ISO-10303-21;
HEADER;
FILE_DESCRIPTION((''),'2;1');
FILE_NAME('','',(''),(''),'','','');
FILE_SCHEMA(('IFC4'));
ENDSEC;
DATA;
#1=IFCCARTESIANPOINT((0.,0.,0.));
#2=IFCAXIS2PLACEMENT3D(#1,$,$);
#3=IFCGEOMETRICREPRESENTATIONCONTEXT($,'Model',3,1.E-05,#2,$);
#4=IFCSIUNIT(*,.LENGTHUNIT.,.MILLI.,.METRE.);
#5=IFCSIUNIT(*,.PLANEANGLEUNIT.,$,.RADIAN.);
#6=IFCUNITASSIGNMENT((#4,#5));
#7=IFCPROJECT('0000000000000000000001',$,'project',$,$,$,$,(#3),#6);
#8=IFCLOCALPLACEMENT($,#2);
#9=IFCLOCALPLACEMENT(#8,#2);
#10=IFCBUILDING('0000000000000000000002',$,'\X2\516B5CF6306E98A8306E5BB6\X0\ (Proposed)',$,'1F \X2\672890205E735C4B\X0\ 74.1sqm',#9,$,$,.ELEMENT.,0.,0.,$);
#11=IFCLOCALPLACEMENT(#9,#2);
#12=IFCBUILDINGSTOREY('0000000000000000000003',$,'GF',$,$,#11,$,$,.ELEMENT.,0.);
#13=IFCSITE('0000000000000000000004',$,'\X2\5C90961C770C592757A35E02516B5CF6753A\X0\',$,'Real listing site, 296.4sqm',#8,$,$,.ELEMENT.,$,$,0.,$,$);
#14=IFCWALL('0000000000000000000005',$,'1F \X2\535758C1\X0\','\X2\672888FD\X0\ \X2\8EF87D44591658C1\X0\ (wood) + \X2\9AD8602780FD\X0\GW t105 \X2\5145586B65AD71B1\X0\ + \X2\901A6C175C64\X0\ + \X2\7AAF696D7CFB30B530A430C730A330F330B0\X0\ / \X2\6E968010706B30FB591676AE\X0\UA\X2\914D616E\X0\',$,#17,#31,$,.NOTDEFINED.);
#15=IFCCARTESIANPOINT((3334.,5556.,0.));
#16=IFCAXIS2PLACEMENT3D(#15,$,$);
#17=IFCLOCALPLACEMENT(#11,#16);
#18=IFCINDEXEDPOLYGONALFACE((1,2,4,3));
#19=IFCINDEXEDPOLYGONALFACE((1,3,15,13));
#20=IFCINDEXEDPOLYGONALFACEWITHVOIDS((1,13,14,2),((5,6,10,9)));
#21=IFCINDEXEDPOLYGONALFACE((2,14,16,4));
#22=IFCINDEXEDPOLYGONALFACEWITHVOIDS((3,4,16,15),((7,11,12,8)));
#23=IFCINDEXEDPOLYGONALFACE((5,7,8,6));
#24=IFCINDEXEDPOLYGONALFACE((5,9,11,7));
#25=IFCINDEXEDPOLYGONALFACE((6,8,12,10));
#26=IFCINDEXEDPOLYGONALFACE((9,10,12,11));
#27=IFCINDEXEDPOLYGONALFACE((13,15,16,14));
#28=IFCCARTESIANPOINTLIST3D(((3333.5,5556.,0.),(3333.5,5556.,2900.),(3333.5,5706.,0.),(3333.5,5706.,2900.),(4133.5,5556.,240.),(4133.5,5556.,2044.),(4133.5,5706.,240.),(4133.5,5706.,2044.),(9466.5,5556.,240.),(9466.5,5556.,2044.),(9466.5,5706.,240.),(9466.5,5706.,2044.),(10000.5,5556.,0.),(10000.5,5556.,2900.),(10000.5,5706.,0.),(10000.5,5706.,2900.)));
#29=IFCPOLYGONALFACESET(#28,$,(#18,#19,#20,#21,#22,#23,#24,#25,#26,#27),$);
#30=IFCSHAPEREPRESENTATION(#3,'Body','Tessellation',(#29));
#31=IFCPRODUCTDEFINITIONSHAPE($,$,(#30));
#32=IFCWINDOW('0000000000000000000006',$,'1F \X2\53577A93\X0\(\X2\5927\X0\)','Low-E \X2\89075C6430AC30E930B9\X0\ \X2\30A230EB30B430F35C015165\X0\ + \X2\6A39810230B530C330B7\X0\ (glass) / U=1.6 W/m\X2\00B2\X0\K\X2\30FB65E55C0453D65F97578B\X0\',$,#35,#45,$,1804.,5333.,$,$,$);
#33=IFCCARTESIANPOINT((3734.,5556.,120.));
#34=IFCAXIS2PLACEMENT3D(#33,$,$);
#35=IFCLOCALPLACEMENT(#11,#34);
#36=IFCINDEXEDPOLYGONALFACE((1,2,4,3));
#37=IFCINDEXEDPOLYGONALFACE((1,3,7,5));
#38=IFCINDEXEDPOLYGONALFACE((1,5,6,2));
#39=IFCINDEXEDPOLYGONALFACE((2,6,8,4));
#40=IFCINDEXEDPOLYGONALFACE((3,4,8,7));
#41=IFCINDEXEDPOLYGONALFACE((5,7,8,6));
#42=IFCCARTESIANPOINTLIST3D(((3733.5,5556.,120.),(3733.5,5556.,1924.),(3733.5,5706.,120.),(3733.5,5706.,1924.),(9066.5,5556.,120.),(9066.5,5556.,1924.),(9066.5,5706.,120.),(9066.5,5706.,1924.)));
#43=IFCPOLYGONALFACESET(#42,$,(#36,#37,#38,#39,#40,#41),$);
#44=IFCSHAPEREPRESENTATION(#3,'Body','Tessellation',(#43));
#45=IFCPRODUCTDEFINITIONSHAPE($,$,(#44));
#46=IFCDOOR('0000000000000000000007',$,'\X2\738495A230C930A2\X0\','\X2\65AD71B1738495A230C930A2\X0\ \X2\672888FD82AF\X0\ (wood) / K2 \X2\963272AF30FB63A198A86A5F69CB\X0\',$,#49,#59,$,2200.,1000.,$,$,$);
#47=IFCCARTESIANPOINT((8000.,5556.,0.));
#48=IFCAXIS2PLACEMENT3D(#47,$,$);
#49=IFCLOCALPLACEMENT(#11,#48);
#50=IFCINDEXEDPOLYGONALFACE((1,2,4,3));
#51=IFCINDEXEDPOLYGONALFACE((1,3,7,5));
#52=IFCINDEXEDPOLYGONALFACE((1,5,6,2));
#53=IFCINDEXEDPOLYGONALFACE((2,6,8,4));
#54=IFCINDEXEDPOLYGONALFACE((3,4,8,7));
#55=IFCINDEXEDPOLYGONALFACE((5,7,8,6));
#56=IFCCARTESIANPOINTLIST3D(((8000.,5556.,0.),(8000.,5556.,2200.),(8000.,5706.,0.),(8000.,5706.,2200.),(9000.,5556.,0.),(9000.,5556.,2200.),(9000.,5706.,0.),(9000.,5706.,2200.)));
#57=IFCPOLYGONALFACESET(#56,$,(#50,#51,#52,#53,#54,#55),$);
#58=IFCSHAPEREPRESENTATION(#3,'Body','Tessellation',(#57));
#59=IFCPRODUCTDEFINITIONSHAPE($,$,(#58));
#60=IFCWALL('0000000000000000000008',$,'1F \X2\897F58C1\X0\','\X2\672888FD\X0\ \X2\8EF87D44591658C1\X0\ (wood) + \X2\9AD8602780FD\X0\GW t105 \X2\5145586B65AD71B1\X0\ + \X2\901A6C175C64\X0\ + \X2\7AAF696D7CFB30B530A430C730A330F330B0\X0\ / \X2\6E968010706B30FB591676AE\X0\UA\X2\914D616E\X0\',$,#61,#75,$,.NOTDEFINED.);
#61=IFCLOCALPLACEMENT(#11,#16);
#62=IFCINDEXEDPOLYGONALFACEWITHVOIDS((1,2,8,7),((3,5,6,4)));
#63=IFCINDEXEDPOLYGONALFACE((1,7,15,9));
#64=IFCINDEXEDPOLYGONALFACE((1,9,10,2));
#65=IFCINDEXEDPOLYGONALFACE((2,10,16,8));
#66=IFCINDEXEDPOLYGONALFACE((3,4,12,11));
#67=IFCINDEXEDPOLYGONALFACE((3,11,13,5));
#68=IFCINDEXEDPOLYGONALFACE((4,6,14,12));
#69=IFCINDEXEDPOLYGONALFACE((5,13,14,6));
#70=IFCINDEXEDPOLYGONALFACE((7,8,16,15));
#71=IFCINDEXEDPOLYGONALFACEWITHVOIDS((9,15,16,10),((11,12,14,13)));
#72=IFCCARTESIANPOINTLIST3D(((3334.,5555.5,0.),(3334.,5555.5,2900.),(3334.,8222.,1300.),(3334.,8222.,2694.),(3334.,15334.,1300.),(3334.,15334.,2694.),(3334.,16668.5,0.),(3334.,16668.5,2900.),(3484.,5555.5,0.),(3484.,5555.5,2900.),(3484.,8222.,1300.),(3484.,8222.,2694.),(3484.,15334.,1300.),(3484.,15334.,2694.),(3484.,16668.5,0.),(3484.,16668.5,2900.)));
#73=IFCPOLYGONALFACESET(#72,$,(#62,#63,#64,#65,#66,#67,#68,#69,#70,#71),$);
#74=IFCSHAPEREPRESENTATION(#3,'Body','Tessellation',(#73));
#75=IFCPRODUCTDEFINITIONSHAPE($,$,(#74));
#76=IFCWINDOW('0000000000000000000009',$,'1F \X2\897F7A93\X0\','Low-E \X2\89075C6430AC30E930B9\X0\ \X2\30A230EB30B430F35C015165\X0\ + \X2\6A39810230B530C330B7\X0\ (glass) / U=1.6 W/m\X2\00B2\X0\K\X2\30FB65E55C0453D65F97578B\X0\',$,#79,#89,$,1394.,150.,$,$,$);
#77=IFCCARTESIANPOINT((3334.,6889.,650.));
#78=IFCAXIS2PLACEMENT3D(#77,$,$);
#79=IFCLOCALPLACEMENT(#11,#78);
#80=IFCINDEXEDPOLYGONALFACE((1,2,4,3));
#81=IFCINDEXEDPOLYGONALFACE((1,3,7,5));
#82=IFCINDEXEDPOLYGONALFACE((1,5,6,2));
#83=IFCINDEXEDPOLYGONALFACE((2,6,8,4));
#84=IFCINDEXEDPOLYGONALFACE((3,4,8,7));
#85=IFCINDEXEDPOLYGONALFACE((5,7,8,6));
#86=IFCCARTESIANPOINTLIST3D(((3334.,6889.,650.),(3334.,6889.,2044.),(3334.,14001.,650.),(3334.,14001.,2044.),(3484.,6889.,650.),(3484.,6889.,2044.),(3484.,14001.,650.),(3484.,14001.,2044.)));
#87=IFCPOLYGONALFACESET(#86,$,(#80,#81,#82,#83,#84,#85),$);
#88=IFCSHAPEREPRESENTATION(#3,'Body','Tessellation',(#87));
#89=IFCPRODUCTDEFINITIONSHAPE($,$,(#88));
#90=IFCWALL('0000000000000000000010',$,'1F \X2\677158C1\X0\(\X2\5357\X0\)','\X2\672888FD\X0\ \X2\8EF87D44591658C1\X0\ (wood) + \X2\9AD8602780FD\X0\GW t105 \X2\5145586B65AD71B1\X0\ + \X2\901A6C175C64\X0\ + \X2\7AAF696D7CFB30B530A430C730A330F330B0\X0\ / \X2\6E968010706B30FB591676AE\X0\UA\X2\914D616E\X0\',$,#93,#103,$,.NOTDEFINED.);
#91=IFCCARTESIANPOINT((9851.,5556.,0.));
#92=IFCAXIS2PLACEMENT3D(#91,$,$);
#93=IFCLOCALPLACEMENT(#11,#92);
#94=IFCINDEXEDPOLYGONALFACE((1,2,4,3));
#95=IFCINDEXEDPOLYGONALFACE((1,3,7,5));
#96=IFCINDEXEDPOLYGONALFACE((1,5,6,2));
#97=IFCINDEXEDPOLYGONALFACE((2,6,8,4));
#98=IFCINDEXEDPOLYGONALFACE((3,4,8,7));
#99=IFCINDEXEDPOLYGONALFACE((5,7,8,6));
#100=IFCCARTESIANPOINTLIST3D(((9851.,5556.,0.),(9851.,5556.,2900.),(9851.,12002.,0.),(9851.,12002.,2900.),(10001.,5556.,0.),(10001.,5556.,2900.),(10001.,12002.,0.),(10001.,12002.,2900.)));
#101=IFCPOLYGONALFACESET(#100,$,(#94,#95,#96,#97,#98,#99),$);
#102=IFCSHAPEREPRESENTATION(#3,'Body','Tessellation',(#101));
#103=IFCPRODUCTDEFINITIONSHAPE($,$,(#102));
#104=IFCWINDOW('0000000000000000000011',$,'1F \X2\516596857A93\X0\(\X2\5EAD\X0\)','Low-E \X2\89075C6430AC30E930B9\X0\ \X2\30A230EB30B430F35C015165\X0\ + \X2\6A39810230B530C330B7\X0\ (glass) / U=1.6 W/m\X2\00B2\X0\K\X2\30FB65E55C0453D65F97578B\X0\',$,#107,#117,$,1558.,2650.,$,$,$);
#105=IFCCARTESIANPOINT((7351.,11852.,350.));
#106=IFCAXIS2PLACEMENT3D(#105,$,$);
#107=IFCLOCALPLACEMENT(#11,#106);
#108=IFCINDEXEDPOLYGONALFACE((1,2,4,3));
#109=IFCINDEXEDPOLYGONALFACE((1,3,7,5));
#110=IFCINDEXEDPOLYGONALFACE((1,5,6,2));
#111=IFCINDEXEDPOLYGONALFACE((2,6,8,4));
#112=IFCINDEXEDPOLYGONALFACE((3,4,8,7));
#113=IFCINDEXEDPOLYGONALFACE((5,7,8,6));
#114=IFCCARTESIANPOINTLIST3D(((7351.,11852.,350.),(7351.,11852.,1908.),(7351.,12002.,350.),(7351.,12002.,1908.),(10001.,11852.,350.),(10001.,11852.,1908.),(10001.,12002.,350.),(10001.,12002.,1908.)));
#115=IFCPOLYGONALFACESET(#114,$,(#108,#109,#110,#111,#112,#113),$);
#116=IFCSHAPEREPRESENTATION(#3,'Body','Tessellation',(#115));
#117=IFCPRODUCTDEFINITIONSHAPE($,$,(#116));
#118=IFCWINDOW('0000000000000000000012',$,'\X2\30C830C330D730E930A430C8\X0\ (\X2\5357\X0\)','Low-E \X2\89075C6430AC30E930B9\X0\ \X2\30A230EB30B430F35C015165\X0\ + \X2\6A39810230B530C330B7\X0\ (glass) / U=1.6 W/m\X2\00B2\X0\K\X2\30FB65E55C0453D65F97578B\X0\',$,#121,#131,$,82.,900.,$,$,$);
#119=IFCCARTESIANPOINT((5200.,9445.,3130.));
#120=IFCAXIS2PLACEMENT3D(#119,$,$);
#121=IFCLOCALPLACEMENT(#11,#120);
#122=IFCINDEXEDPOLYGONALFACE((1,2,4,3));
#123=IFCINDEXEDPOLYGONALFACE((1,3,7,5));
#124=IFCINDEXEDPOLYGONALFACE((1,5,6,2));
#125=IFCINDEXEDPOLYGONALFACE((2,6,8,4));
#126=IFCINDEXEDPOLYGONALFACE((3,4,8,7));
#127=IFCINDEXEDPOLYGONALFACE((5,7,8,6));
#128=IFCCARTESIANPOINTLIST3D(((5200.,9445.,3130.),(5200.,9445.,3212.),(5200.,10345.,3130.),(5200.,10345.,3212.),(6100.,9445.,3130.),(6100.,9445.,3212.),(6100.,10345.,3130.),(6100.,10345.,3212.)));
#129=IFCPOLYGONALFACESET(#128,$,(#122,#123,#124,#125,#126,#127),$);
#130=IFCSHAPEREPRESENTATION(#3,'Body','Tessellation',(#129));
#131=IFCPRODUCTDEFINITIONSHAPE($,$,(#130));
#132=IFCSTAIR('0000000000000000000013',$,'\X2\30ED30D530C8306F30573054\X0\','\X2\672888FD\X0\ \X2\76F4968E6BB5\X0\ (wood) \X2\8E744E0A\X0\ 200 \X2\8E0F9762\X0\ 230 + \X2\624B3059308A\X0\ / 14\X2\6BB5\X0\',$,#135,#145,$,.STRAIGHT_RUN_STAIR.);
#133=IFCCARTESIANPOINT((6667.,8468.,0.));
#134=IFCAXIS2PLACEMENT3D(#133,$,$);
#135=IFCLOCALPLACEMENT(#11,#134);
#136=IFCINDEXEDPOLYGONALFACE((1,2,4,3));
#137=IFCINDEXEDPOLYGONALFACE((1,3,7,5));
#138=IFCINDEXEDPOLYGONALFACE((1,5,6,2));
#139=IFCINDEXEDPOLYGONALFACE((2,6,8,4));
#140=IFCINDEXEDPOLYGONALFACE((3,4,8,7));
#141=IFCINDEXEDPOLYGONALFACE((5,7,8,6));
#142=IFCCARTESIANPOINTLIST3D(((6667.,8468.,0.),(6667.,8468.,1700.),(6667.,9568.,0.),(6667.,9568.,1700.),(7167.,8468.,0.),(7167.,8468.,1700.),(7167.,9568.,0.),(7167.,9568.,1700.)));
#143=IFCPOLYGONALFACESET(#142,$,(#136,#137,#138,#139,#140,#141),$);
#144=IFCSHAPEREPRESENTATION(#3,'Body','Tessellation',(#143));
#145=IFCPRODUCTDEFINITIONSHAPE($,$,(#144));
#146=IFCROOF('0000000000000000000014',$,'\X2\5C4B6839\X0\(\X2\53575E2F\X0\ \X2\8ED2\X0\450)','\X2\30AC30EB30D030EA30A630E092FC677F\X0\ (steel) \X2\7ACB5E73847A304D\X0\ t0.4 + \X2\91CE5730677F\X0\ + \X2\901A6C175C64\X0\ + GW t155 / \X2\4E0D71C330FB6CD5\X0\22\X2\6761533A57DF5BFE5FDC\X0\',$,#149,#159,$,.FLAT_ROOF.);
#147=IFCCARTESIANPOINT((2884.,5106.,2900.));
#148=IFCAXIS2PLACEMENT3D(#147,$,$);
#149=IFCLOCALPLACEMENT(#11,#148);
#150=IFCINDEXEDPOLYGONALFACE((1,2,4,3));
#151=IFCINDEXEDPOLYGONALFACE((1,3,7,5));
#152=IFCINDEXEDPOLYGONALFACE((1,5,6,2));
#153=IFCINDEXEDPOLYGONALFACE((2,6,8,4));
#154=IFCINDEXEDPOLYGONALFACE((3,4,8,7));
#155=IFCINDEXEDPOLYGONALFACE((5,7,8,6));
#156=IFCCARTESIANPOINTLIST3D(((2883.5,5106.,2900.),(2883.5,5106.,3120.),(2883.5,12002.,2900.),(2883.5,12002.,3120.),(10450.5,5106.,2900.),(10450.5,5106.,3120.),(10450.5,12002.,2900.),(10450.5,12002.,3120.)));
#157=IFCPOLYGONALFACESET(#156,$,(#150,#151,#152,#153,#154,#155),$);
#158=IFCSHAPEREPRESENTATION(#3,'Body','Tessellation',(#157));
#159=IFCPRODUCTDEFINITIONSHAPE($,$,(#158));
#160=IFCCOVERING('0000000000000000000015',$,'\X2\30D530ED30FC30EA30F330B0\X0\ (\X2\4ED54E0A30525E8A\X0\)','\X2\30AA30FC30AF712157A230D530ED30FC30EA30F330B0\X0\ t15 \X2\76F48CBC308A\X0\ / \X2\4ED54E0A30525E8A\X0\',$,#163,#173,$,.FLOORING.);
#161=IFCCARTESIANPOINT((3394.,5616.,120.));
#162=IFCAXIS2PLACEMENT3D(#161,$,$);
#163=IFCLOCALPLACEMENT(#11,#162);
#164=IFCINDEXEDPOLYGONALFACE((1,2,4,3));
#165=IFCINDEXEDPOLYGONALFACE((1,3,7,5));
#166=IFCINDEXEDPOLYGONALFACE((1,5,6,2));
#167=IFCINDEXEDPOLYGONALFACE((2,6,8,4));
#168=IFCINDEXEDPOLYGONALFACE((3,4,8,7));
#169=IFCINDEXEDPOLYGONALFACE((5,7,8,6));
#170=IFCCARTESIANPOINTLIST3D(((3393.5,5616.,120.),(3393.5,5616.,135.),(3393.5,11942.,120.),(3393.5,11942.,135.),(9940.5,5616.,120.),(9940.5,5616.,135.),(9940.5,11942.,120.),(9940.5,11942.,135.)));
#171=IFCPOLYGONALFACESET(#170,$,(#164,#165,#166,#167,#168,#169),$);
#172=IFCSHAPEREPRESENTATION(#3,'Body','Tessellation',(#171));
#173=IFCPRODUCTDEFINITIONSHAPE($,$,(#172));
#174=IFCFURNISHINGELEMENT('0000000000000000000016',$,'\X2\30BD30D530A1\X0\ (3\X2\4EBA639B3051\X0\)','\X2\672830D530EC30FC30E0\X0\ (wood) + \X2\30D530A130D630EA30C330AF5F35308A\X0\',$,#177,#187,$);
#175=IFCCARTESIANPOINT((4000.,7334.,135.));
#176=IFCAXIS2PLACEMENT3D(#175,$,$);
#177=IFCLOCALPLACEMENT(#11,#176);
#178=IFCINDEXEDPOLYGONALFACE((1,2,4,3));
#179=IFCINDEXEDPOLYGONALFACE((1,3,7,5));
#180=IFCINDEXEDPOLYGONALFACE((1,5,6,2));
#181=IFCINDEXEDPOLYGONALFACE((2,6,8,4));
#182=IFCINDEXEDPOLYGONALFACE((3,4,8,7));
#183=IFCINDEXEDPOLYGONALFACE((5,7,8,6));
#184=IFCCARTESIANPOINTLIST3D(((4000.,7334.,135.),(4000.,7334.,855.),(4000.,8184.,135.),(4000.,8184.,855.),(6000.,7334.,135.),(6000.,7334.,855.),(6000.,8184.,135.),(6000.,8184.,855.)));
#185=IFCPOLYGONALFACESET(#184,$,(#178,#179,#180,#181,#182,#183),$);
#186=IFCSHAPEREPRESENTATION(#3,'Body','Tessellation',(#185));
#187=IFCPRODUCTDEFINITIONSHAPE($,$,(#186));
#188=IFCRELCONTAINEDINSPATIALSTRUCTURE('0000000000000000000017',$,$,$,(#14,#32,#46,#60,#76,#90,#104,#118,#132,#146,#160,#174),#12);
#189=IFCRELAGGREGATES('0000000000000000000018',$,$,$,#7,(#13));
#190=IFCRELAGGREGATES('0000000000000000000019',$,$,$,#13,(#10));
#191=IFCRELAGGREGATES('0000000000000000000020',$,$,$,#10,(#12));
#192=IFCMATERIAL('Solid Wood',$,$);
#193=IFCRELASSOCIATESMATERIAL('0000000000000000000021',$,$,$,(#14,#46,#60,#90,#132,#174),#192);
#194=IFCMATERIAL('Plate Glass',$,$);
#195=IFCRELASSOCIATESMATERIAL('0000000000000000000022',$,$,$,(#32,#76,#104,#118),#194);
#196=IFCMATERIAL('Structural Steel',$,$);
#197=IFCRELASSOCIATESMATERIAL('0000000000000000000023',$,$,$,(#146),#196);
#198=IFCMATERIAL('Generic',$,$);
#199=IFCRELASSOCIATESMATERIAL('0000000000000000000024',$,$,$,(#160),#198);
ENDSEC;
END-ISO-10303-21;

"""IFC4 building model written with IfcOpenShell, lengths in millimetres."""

from ifc_helpers import new_model, si_unit, frame, frame_2d, origin, place, context, project, spatial, rectangle, extrude, material, element, fill, save


model = new_model("IFC4")

# Units and contexts
model_context = context("Model", 3, precision=1e-05, world=origin())
ifc_project = project(units=[si_unit("LENGTHUNIT", "METRE", prefix="MILLI"), si_unit("PLANEANGLEUNIT", "RADIAN")], contexts=[model_context])

# Site, building, storey
site_placement = place(None, origin())
site = spatial("IfcSite", under=ifc_project, at=site_placement, Name="岐阜県大垣市八島町", ObjectType="Real listing site, 296.4sqm", CompositionType="ELEMENT", RefElevation=0.0)
building_placement = place(site_placement, origin())
building = spatial("IfcBuilding", under=site, at=building_placement, Name="八島の風の家 (Proposed)", ObjectType="1F 木造平屋 74.1sqm", CompositionType="ELEMENT", ElevationOfRefHeight=0.0, ElevationOfTerrain=0.0)
storey_placement = place(building_placement, origin())
storey = spatial("IfcBuildingStorey", under=building, at=storey_placement, Name="GF", CompositionType="ELEMENT", Elevation=0.0)

# Shared definitions
ifc_material_1 = material(Name="Solid Wood")

# Wall, openings, window, door
wall_1_placement = place(storey_placement, frame((3334.0, 5556.0, 0.0)))
wall_1 = element("IfcWall", 1, at=wall_1_placement, inside=storey, material=ifc_material_1, Name="1F 南壁", Description="木製 軸組外壁 (wood) + 高性能GW t105 充填断熱 + 通気層 + 窯業系サイディング / 準耐火・外皮UA配慮", PredefinedType="NOTDEFINED", context=model_context, shape_type="SweptSolid", body=[
    extrude(rectangle(XDim=6667.0, YDim=150.0, at=frame_2d((3333.0, 75.0))), frame((3334.0, 5556.0, 0.0)), (0.0, 0.0, 1.0), 2900.0),
])
opening_1_placement = place(storey_placement, frame((3734.0, 5556.0, 120.0)))
opening_1 = element("IfcOpeningElement", 2, at=opening_1_placement, cuts=wall_1, PredefinedType="NOTDEFINED", context=model_context, shape_type="SweptSolid", body=[
    extrude(rectangle(XDim=5333.0, YDim=150.0, at=frame_2d((2666.0, 75.0))), frame((3734.0, 5556.0, 120.0)), (0.0, 0.0, 1.0), 1804.0),
])
opening_2_placement = place(storey_placement, frame((8000.0, 5556.0, 0.0)))
opening_2 = element("IfcOpeningElement", 3, at=opening_2_placement, cuts=wall_1, PredefinedType="NOTDEFINED", context=model_context, shape_type="SweptSolid", body=[
    extrude(rectangle(XDim=1000.0, YDim=150.0, at=frame_2d((500.0, 75.0))), frame((8000.0, 5556.0, 0.0)), (0.0, 0.0, 1.0), 2200.0),
])
ifc_material_2 = material(Name="Plate Glass")
window_1_placement = place(storey_placement, frame((3734.0, 5556.0, 120.0)))
window_1 = element("IfcWindow", 4, at=window_1_placement, inside=storey, material=ifc_material_2, Name="1F 南窓(大)", Description="Low-E 複層ガラス アルゴン封入 + 樹脂サッシ (glass) / U=1.6 W/m²K・日射取得型", OverallHeight=1804.0, OverallWidth=5333.0, context=model_context, shape_type="SweptSolid", body=[
    extrude(rectangle(XDim=5333.0, YDim=150.0, at=frame_2d((2666.0, 75.0))), frame((3734.0, 5556.0, 120.0)), (0.0, 0.0, 1.0), 1804.0),
])
fill(opening_1, window_1)
door_1_placement = place(storey_placement, frame((8000.0, 5556.0, 0.0)))
door_1 = element("IfcDoor", 5, at=door_1_placement, inside=storey, material=ifc_material_1, Name="玄関ドア", Description="断熱玄関ドア 木製芯 (wood) / K2 防犯・採風機構", OverallHeight=2200.0, OverallWidth=1000.0, context=model_context, shape_type="SweptSolid", body=[
    extrude(rectangle(XDim=1000.0, YDim=150.0, at=frame_2d((500.0, 75.0))), frame((8000.0, 5556.0, 0.0)), (0.0, 0.0, 1.0), 2200.0),
])
fill(opening_2, door_1)

# Walls, openings, windows
wall_2_placement = place(storey_placement, frame((3334.0, 5556.0, 0.0)))
wall_2 = element("IfcWall", 6, at=wall_2_placement, inside=storey, material=ifc_material_1, Name="1F 西壁", Description="木製 軸組外壁 (wood) + 高性能GW t105 充填断熱 + 通気層 + 窯業系サイディング / 準耐火・外皮UA配慮", PredefinedType="NOTDEFINED", context=model_context, shape_type="SweptSolid", body=[
    extrude(rectangle(XDim=150.0, YDim=11113.0, at=frame_2d((75.0, 5556.0))), frame((3334.0, 5556.0, 0.0)), (0.0, 0.0, 1.0), 2900.0),
])
opening_3_placement = place(storey_placement, frame((3334.0, 6889.0, 650.0)))
opening_3 = element("IfcOpeningElement", 7, at=opening_3_placement, cuts=wall_2, PredefinedType="NOTDEFINED", context=model_context, shape_type="SweptSolid", body=[
    extrude(rectangle(XDim=150.0, YDim=7112.0, at=frame_2d((75.0, 3556.0))), frame((3334.0, 6889.0, 650.0)), (0.0, 0.0, 1.0), 1394.0),
])
window_2_placement = place(storey_placement, frame((3334.0, 6889.0, 650.0)))
window_2 = element("IfcWindow", 8, at=window_2_placement, inside=storey, material=ifc_material_2, Name="1F 西窓", Description="Low-E 複層ガラス アルゴン封入 + 樹脂サッシ (glass) / U=1.6 W/m²K・日射取得型", OverallHeight=1394.0, OverallWidth=150.0, context=model_context, shape_type="SweptSolid", body=[
    extrude(rectangle(XDim=150.0, YDim=7112.0, at=frame_2d((75.0, 3556.0))), frame((3334.0, 6889.0, 650.0)), (0.0, 0.0, 1.0), 1394.0),
])
fill(opening_3, window_2)
wall_3_placement = place(storey_placement, frame((9851.0, 5556.0, 0.0)))
wall_3 = element("IfcWall", 9, at=wall_3_placement, inside=storey, material=ifc_material_1, Name="1F 東壁(南)", Description="木製 軸組外壁 (wood) + 高性能GW t105 充填断熱 + 通気層 + 窯業系サイディング / 準耐火・外皮UA配慮", PredefinedType="NOTDEFINED", context=model_context, shape_type="SweptSolid", body=[
    extrude(rectangle(XDim=150.0, YDim=6446.0, at=frame_2d((75.0, 3223.0))), frame((9851.0, 5556.0, 0.0)), (0.0, 0.0, 1.0), 2900.0),
])
opening_4_placement = place(storey_placement, frame((7351.0, 11852.0, 350.0)))
opening_4 = element("IfcOpeningElement", 10, at=opening_4_placement, cuts=wall_3, PredefinedType="NOTDEFINED", context=model_context, shape_type="SweptSolid", body=[
    extrude(rectangle(XDim=2650.0, YDim=150.0, at=frame_2d((1325.0, 75.0))), frame((7351.0, 11852.0, 350.0)), (0.0, 0.0, 1.0), 1558.0),
])
window_3_placement = place(storey_placement, frame((7351.0, 11852.0, 350.0)))
window_3 = element("IfcWindow", 11, at=window_3_placement, inside=storey, material=ifc_material_2, Name="1F 入隅窓(庭)", Description="Low-E 複層ガラス アルゴン封入 + 樹脂サッシ (glass) / U=1.6 W/m²K・日射取得型", OverallHeight=1558.0, OverallWidth=2650.0, context=model_context, shape_type="SweptSolid", body=[
    extrude(rectangle(XDim=2650.0, YDim=150.0, at=frame_2d((1325.0, 75.0))), frame((7351.0, 11852.0, 350.0)), (0.0, 0.0, 1.0), 1558.0),
])
fill(opening_4, window_3)

# Window
window_4_placement = place(storey_placement, frame((5200.0, 9445.0, 3130.0)))
element("IfcWindow", 12, at=window_4_placement, inside=storey, material=ifc_material_2, Name="トップライト (南)", Description="Low-E 複層ガラス アルゴン封入 + 樹脂サッシ (glass) / U=1.6 W/m²K・日射取得型", OverallHeight=82.0, OverallWidth=900.0, context=model_context, shape_type="SweptSolid", body=[
    extrude(rectangle(XDim=900.0, YDim=900.0, at=frame_2d((450.0, 450.0))), frame((5200.0, 9445.0, 3130.0)), (0.0, 0.0, 1.0), 82.0),
])

# Stair
stair_placement = place(storey_placement, frame((6667.0, 8468.0, 0.0)))
element("IfcStair", 13, at=stair_placement, inside=storey, material=ifc_material_1, Name="ロフトはしご", Description="木製 直階段 (wood) 蹴上 200 踏面 230 + 手すり / 14段", PredefinedType="STRAIGHT_RUN_STAIR", context=model_context, shape_type="SweptSolid", body=[
    extrude(rectangle(XDim=500.0, YDim=1100.0, at=frame_2d((250.0, 550.0))), frame((6667.0, 8468.0, 0.0)), (0.0, 0.0, 1.0), 1700.0),
])

# Roof
ifc_material_3 = material(Name="Structural Steel")
roof_placement = place(storey_placement, frame((2884.0, 5106.0, 2900.0)))
element("IfcRoof", 14, at=roof_placement, inside=storey, material=ifc_material_3, Name="屋根(南帯 軒450)", Description="ガルバリウム鋼板 (steel) 立平葺き t0.4 + 野地板 + 通気層 + GW t155 / 不燃・法22条区域対応", PredefinedType="FLAT_ROOF", context=model_context, shape_type="SweptSolid", body=[
    extrude(rectangle(XDim=7567.0, YDim=6896.0, at=frame_2d((3783.0, 3448.0))), frame((2884.0, 5106.0, 2900.0)), (0.0, 0.0, 1.0), 220.0),
])

# Covering
ifc_material_4 = material(Name="Generic")
covering_placement = place(storey_placement, frame((3394.0, 5616.0, 120.0)))
element("IfcCovering", 15, at=covering_placement, inside=storey, material=ifc_material_4, Name="フローリング (仕上げ床)", Description="オーク無垢フローリング t15 直貼り / 仕上げ床", PredefinedType="FLOORING", context=model_context, shape_type="SweptSolid", body=[
    extrude(rectangle(XDim=6547.0, YDim=6326.0, at=frame_2d((3273.0, 3163.0))), frame((3394.0, 5616.0, 120.0)), (0.0, 0.0, 1.0), 15.0),
])

# Furnishing element
furnishing_1_placement = place(storey_placement, frame((4000.0, 7334.0, 135.0)))
element("IfcFurnishingElement", 16, at=furnishing_1_placement, inside=storey, material=ifc_material_1, Name="ソファ (3人掛け)", Description="木フレーム (wood) + ファブリック張り", context=model_context, shape_type="SweptSolid", body=[
    extrude(rectangle(XDim=2000.0, YDim=850.0, at=frame_2d((1000.0, 425.0))), frame((4000.0, 7334.0, 135.0)), (0.0, 0.0, 1.0), 720.0),
])

save(model, "model.ifc")
